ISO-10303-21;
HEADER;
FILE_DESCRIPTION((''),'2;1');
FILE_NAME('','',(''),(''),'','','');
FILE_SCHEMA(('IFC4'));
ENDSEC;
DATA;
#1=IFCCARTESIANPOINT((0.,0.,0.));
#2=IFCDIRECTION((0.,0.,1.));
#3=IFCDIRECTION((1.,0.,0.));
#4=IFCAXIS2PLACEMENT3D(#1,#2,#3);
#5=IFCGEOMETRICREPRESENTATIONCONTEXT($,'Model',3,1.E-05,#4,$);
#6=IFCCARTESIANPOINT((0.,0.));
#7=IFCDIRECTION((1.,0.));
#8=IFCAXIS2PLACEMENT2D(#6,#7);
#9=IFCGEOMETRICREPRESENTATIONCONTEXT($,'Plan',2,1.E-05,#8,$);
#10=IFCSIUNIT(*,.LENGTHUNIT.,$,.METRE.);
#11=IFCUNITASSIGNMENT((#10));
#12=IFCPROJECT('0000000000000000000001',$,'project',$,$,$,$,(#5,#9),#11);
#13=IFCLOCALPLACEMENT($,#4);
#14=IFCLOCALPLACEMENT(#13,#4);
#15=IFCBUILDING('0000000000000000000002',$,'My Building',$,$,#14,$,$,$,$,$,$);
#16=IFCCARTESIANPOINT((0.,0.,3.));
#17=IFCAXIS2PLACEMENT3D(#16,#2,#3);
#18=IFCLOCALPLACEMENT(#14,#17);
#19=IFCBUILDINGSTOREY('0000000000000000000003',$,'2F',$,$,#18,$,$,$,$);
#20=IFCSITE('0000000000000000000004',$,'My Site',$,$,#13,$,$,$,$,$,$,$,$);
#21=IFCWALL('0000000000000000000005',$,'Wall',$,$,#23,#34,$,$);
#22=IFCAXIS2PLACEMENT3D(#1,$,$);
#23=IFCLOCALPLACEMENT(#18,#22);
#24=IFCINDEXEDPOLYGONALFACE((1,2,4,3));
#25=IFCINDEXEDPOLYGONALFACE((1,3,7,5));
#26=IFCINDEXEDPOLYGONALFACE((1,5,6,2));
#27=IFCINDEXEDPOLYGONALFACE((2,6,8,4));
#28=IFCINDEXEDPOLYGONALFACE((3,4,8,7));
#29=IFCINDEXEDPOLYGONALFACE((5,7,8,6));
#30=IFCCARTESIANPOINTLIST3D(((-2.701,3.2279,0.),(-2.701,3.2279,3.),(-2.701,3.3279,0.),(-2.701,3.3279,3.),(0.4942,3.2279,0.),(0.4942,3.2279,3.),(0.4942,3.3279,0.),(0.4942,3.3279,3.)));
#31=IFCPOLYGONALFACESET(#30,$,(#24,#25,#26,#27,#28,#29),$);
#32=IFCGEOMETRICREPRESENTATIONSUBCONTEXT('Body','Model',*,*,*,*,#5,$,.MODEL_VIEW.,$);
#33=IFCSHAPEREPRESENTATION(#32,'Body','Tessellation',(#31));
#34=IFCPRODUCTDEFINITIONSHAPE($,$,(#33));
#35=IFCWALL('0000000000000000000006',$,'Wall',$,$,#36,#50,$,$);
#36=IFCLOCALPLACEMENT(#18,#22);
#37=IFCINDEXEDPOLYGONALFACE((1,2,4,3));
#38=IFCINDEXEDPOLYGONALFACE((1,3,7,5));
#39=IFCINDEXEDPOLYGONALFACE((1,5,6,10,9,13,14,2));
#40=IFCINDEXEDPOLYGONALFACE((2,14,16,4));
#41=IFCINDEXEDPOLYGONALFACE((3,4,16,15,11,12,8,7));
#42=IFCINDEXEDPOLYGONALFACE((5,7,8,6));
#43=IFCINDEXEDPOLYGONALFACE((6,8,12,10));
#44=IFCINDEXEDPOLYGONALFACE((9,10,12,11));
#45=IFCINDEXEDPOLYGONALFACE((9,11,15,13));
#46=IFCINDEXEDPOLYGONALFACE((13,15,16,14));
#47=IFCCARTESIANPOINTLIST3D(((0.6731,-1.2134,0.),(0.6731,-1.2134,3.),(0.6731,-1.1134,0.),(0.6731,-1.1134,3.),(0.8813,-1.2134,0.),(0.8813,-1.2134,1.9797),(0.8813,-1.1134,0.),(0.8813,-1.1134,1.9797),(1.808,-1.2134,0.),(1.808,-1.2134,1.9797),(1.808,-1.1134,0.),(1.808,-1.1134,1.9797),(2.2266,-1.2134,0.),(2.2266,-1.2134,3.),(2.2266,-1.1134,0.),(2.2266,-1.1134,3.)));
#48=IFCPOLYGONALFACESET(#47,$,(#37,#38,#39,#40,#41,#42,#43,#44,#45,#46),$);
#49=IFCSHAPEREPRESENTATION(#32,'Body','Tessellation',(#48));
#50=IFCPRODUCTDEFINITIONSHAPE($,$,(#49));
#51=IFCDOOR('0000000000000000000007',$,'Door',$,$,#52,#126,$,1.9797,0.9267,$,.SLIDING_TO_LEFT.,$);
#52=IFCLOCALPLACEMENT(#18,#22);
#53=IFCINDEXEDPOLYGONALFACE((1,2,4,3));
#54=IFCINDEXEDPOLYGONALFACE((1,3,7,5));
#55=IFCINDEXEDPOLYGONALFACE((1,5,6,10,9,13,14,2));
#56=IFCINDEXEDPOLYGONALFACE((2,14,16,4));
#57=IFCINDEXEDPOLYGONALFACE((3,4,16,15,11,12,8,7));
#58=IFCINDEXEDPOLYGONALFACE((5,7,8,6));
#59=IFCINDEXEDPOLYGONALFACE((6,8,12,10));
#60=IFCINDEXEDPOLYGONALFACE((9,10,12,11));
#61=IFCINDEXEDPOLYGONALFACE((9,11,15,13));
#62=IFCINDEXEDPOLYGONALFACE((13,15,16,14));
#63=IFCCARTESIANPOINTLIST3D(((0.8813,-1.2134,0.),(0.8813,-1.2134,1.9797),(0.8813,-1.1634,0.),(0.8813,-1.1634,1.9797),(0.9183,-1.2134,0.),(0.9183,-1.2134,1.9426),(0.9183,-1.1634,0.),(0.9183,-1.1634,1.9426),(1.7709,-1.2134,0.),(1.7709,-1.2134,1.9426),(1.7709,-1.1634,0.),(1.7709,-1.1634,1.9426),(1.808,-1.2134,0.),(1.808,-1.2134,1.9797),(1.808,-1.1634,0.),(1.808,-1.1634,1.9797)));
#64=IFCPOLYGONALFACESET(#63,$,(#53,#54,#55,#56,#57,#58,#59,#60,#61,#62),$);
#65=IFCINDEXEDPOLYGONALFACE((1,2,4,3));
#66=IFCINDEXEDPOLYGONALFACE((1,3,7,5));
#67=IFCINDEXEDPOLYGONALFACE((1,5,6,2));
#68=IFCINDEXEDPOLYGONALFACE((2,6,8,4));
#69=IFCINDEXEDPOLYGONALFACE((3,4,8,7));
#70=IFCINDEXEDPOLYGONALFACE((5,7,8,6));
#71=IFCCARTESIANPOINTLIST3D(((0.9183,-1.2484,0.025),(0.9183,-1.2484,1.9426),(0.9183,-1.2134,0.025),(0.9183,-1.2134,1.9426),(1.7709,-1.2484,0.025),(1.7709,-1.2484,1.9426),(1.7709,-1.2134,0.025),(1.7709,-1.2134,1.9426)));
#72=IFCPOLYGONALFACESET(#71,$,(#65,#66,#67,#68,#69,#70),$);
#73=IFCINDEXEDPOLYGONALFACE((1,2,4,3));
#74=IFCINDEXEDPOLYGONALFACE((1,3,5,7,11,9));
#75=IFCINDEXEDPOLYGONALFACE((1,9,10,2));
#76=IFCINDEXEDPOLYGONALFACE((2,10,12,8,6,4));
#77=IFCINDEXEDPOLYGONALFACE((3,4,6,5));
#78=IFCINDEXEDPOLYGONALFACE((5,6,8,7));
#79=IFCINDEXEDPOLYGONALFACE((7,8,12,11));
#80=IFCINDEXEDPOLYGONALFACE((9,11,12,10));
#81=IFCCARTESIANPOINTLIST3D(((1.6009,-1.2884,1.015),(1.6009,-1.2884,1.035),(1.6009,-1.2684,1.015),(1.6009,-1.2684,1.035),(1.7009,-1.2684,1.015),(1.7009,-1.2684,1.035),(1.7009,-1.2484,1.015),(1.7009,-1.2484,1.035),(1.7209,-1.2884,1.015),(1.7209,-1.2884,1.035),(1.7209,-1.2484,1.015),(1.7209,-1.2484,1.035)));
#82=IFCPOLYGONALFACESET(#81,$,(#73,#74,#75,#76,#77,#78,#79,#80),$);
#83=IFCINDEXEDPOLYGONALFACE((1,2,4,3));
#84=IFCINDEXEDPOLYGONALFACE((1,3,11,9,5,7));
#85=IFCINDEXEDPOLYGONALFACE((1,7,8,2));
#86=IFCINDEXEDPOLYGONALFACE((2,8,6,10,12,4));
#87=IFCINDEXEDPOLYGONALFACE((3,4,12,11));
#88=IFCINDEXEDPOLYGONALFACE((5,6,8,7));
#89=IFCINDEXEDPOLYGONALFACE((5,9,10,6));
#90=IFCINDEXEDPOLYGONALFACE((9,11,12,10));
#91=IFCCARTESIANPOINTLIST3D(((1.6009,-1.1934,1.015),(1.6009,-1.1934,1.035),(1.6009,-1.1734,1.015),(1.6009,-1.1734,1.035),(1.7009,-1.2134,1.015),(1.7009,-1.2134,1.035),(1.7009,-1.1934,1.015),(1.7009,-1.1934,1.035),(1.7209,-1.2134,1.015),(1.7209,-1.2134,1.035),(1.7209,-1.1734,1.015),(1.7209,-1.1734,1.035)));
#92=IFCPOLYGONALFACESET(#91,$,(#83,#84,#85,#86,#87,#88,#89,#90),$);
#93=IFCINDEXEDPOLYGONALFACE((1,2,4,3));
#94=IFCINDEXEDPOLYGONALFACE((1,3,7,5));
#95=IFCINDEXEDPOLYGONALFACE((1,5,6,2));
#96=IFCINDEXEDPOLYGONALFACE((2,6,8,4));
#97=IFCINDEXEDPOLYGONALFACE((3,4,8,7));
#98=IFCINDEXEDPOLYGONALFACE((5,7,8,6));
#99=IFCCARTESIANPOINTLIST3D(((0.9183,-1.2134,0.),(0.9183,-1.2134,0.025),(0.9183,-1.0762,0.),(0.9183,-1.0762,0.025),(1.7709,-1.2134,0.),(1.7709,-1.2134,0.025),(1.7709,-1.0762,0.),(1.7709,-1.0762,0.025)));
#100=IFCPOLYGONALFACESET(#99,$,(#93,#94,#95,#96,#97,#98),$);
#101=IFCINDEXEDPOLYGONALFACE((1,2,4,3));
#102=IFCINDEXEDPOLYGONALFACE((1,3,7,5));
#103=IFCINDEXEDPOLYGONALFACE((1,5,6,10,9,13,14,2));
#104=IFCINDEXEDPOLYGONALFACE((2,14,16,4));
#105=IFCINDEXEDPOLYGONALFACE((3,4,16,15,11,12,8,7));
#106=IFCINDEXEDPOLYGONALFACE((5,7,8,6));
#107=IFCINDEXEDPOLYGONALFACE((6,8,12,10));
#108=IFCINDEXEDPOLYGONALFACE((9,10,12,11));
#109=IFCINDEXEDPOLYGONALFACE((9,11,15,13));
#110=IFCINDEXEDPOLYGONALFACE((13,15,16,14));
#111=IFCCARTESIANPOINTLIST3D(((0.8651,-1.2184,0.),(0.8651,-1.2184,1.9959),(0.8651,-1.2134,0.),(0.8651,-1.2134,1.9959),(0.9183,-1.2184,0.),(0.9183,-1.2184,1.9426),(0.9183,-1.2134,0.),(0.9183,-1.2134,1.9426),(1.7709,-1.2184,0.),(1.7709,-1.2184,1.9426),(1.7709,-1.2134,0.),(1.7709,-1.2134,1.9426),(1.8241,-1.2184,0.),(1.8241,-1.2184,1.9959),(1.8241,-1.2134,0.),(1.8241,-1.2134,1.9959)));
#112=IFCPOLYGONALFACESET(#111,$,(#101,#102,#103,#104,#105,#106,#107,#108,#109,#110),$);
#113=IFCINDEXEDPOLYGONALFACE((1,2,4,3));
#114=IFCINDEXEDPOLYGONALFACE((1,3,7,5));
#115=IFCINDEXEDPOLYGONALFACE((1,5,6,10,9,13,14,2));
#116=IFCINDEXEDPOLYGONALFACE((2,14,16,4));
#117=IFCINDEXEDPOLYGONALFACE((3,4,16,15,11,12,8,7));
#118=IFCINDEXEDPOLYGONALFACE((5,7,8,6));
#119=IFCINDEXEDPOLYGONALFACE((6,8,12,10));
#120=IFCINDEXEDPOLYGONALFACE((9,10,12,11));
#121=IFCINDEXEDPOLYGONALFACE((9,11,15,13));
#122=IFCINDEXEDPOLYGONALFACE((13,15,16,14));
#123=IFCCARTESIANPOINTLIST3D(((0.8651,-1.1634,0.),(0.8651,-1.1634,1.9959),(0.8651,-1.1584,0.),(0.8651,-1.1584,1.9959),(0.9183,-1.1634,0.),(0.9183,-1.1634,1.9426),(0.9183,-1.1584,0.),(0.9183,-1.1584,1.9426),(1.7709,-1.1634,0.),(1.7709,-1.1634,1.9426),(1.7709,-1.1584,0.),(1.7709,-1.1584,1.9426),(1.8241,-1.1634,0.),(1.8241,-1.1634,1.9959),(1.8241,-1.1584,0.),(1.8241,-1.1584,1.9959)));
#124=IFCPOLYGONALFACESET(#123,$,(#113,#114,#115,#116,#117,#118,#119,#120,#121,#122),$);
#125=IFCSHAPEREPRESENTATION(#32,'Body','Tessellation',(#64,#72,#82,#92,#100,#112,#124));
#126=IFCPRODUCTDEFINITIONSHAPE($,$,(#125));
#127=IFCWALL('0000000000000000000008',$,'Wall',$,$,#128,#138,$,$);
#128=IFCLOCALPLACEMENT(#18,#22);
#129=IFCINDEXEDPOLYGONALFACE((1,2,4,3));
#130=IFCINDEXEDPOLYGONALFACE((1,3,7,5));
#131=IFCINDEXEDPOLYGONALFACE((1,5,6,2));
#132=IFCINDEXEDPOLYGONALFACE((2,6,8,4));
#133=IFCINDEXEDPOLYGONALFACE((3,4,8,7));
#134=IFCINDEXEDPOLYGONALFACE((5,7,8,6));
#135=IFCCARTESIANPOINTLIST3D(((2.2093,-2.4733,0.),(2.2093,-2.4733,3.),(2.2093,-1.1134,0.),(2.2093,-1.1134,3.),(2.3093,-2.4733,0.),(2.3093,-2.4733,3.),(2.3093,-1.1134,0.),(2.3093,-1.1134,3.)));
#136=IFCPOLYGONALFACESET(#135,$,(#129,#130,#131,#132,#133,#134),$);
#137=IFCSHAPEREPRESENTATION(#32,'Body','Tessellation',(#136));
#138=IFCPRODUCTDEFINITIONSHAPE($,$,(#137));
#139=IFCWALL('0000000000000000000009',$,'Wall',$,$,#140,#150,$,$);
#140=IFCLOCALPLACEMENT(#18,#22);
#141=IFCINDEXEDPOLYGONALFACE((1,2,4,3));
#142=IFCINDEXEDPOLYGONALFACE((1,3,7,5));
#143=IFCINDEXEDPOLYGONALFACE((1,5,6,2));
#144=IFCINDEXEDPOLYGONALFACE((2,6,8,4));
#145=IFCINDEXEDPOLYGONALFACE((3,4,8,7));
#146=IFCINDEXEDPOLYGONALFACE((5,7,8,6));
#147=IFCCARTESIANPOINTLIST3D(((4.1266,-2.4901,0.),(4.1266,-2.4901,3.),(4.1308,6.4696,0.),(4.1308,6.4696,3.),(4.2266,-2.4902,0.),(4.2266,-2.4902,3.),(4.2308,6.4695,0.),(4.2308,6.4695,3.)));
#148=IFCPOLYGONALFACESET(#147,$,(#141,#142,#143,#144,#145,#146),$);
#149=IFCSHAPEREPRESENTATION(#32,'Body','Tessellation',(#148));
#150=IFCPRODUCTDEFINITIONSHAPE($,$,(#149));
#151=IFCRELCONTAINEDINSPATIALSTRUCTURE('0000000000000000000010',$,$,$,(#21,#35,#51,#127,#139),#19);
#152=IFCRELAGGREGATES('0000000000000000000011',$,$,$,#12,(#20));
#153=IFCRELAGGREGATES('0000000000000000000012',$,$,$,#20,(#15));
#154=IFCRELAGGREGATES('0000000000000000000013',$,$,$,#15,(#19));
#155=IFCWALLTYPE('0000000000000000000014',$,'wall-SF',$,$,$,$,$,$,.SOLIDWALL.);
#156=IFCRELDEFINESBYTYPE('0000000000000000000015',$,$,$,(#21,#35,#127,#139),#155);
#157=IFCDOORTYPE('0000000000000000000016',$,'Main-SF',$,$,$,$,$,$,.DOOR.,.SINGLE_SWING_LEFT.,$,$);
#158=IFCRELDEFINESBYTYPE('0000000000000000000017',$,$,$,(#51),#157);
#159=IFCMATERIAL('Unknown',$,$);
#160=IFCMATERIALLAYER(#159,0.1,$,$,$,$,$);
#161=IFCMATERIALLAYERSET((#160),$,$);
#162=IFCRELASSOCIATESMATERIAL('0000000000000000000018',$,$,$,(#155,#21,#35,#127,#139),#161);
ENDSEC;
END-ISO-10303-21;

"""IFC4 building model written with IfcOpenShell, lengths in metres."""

from ifc_helpers import new_model, entity, si_unit, frame, origin_with_axes, origin_2d_with_axis, place, context, subcontext, project, spatial, line, indexed_curve, outline, extrude, shape, source, transform, mapped, material, layer, layer_set, layer_usage, type_object, type_shapes, element, fill, save


model = new_model("IFC4")

# Units and contexts
model_context = context("Model", 3, precision=1e-05, world=origin_with_axes())
plan_context = context("Plan", 2, precision=1e-05, world=origin_2d_with_axis())
body_context_1 = subcontext(model_context, "Body", "Model", "MODEL_VIEW")
body_context_2 = subcontext(plan_context, "Body", "Plan", "PLAN_VIEW")
ifc_project = project(units=[si_unit("LENGTHUNIT", "METRE")], contexts=[model_context, plan_context])

# Site, building, storey
site_placement = place(None, origin_with_axes())
site = spatial("IfcSite", under=ifc_project, at=site_placement, Name="My Site")
building_placement = place(site_placement, origin_with_axes())
building = spatial("IfcBuilding", under=site, at=building_placement, Name="My Building")
storey_placement = place(building_placement, frame((0.0, 0.0, 3.0), z_axis=(0.0, 0.0, 1.0), x_axis=(1.0, 0.0, 0.0)))
storey = spatial("IfcBuildingStorey", under=building, at=storey_placement, Name="2F")

# Shared definitions
ifc_material = material(Name="Unknown")

# Shared definitions
ifc_layer_1 = layer(ifc_material, 0.1)
ifc_layer_set_1 = layer_set([ifc_layer_1])
wall_type = type_object("IfcWallType", Name="wall-SF", PredefinedType="SOLIDWALL", material=ifc_layer_set_1)

# Wall
ifc_layer_usage_1 = layer_usage(ifc_layer_set_1, "AXIS2", "POSITIVE", 0.0)
wall_1_placement = place(storey_placement, frame((0.4942, 3.3279, 0.0), z_axis=(0.0, 0.0, 1.0), x_axis=(-1.0, 0.0, 0.0)))
element("IfcWall", 1, at=wall_1_placement, inside=storey, type_object=wall_type, material=ifc_layer_usage_1, Name="Wall", context=body_context_1, shape_type="SweptSolid", body=[
    extrude(outline(indexed_curve([(0.0, 0.0), (0.0, 0.1), (3.1952, 0.1), (3.1952, 0.0)], segments=[line(1, 2, 3, 4, 1)])), origin_with_axes(), (0.0, 0.0, 1.0), 3.0),
])

# Wall, opening, door
ifc_layer_usage_2 = layer_usage(ifc_layer_set_1, "AXIS2", "POSITIVE", 0.0)
wall_2_placement = place(storey_placement, frame((0.6731, -1.2134, 0.0), z_axis=(0.0, 0.0, 1.0), x_axis=(1.0, 0.0, 0.0)))
wall_2 = element("IfcWall", 2, at=wall_2_placement, inside=storey, type_object=wall_type, material=ifc_layer_usage_2, Name="Wall", context=body_context_1, shape_type="SweptSolid", body=[
    extrude(outline(indexed_curve([(0.0, 0.0), (0.0, 0.1), (1.5535, 0.1), (1.5535, 0.0)], segments=[line(1, 2, 3, 4, 1)])), origin_with_axes(), (0.0, 0.0, 1.0), 3.0),
])
shared_shape_1 = source(origin_with_axes(), body_context_1, "Body", "SweptSolid", [
    extrude(outline(indexed_curve([(0.0, 0.0), (0.9267, 0.0), (0.9267, 1.9797), (0.0, 1.9797)], segments=[line(1, 2, 3, 4, 1)])), frame((0.0, -0.6, 0.0), z_axis=(0.0, -1.0, 0.0), x_axis=(1.0, 0.0, 0.0)), (0.0, 0.0, -1.0), 1.2),
])
opening_1_placement = place(wall_2_placement, frame((0.2082, 0.0, 0.0), z_axis=(0.0, 0.0, 1.0), x_axis=(1.0, 0.0, 0.0)))
opening_1 = element("IfcOpeningElement", 3, at=opening_1_placement, cuts=wall_2, PredefinedType="OPENING", context=body_context_1, shape_type="MappedRepresentation", body=[
    mapped(shared_shape_1, transform((0.0, 0.0, 0.0), x_axis=(1.0, 0.0, 0.0), y_axis=(0.0, 1.0, 0.0), z_axis=(0.0, 0.0, 1.0), scale=1.0)),
])
door_type_1 = type_object("IfcDoorType", Name="Main-SF", OperationType="SINGLE_SWING_LEFT", PredefinedType="DOOR")
shared_shape_2 = source(origin_with_axes(), body_context_1, "Body", "SweptSolid", [
    extrude(outline(indexed_curve([(0.0, 0.0), (0.0, 1.9797), (0.9267, 1.9797), (0.9267, 0.0), (0.8896, 0.0), (0.8896, 1.9426), (0.0371, 1.9426), (0.0371, 0.0)], segments=[line(1, 2, 3, 4, 5, 6, 7, 8, 1)])), frame((0.0, 0.0, 0.0), z_axis=(0.0, -1.0, 0.0), x_axis=(1.0, 0.0, 0.0)), (0.0, 0.0, -1.0), 0.05),
    extrude(outline(indexed_curve([(0.0, 0.0), (0.8526, 0.0), (0.8526, 0.035), (0.0, 0.035)], segments=[line(1, 2, 3, 4, 1)])), frame((0.0371, -0.035, 0.025), z_axis=(0.0, 0.0, 1.0), x_axis=(1.0, 0.0, 0.0)), (0.0, 0.0, 1.0), 1.9176),
    extrude(outline(indexed_curve([(0.0, 0.0), (0.0, -0.04), (-0.12, -0.04), (-0.12, -0.02), (-0.02, -0.02), (-0.02, 0.0)], segments=[line(1, 2, 3, 4, 5, 6, 1)])), frame((0.8396, -0.035, 1.015), z_axis=(0.0, 0.0, 1.0), x_axis=(1.0, 0.0, 0.0)), (0.0, 0.0, 1.0), 0.02),
    extrude(outline(indexed_curve([(0.0, 0.0), (0.0, 0.04), (-0.12, 0.04), (-0.12, 0.02), (-0.02, 0.02), (-0.02, 0.0)], segments=[line(1, 2, 3, 4, 5, 6, 1)])), frame((0.8396, 0.0, 1.015), z_axis=(0.0, 0.0, 1.0), x_axis=(1.0, 0.0, 0.0)), (0.0, 0.0, 1.0), 0.02),
    extrude(outline(indexed_curve([(0.0, 0.0), (0.8526, 0.0), (0.8526, 0.1372), (0.0, 0.1372)], segments=[line(1, 2, 3, 4, 1)])), frame((0.0371, 0.0, 0.0), z_axis=(0.0, 0.0, 1.0), x_axis=(1.0, 0.0, 0.0)), (0.0, 0.0, 1.0), 0.025),
    extrude(outline(indexed_curve([(0.0, 0.0), (0.0, 1.9959), (0.959, 1.9959), (0.959, 0.0), (0.9058, 0.0), (0.9058, 1.9426), (0.0532, 1.9426), (0.0532, 0.0)], segments=[line(1, 2, 3, 4, 5, 6, 7, 8, 1)])), frame((-0.0162, -0.005, 0.0), z_axis=(0.0, -1.0, 0.0), x_axis=(1.0, 0.0, 0.0)), (0.0, 0.0, -1.0), 0.005),
    extrude(outline(indexed_curve([(0.0, 0.0), (0.0, 1.9959), (0.959, 1.9959), (0.959, 0.0), (0.9058, 0.0), (0.9058, 1.9426), (0.0532, 1.9426), (0.0532, 0.0)], segments=[line(1, 2, 3, 4, 5, 6, 7, 8, 1)])), frame((-0.0162, 0.05, 0.0), z_axis=(0.0, -1.0, 0.0), x_axis=(1.0, 0.0, 0.0)), (0.0, 0.0, -1.0), 0.005),
])
shared_shape_3 = source(origin_with_axes(), body_context_2, "Body", "Curve2D", [
    entity("IfcIndexedPolyCurve", entity("IfcCartesianPointList2D", [[0.0, 0.0], [0.0371, 0.0], [0.0371, 0.05], [0.0, 0.05]]), [entity("IfcLineIndex", [1, 2, 3, 4, 1])]),
    entity("IfcIndexedPolyCurve", entity("IfcCartesianPointList2D", [[0.9267, 0.0], [0.8896, 0.0], [0.8896, 0.05], [0.9267, 0.05]]), [entity("IfcLineIndex", [1, 2, 3, 4, 1])]),
    entity("IfcIndexedPolyCurve", entity("IfcCartesianPointList2D", [[-0.3892, -0.035], [0.4634, -0.035], [0.4634, 0.0], [-0.3892, 0.0]]), [entity("IfcLineIndex", [1, 2, 3, 4, 1])]),
])
type_shapes(door_type_1, [shared_shape_2, shared_shape_3])
door_1_placement = place(opening_1_placement, origin_with_axes())
door_1 = element("IfcDoor", 4, at=door_1_placement, inside=storey, type_object=door_type_1, Name="Door", OperationType="SLIDING_TO_LEFT", OverallHeight=1.9797, OverallWidth=0.9267, shapes=[
    shape(body_context_1, "Body", "MappedRepresentation", [mapped(shared_shape_2, transform((0.0, 0.0, 0.0), x_axis=(1.0, 0.0, 0.0), y_axis=(0.0, 1.0, 0.0), z_axis=(0.0, 0.0, 1.0), scale=1.0))]),
    shape(body_context_2, "Body", "MappedRepresentation", [mapped(shared_shape_3, transform((0.0, 0.0, 0.0), x_axis=(1.0, 0.0, 0.0), y_axis=(0.0, 1.0, 0.0), z_axis=(0.0, 0.0, 1.0), scale=1.0))]),
])
fill(opening_1, door_1)

# Walls
ifc_layer_usage_3 = layer_usage(ifc_layer_set_1, "AXIS2", "POSITIVE", 0.0)
wall_3_placement = place(storey_placement, frame((2.2093, -1.1134, 0.0), z_axis=(0.0, 0.0, 1.0), x_axis=(0.0, -1.0, 0.0)))
element("IfcWall", 5, at=wall_3_placement, inside=storey, type_object=wall_type, material=ifc_layer_usage_3, Name="Wall", context=body_context_1, shape_type="SweptSolid", body=[
    extrude(outline(indexed_curve([(0.0, 0.0), (0.0, 0.1), (1.3599, 0.1), (1.3599, 0.0)], segments=[line(1, 2, 3, 4, 1)])), origin_with_axes(), (0.0, 0.0, 1.0), 3.0),
])
ifc_layer_usage_4 = layer_usage(ifc_layer_set_1, "AXIS2", "POSITIVE", 0.0)
wall_4_placement = place(storey_placement, frame((4.1308, 6.4696, 0.0), z_axis=(0.0, 0.0, 1.0), x_axis=(-0.000467, -1.0, 0.0)))
element("IfcWall", 6, at=wall_4_placement, inside=storey, type_object=wall_type, material=ifc_layer_usage_4, Name="Wall", context=body_context_1, shape_type="SweptSolid", body=[
    extrude(outline(indexed_curve([(0.0, 0.0), (0.0, 0.1), (8.9597, 0.1), (8.9597, 0.0)], segments=[line(1, 2, 3, 4, 1)])), origin_with_axes(), (0.0, 0.0, 1.0), 3.0),
])

save(model, "model.ifc")
